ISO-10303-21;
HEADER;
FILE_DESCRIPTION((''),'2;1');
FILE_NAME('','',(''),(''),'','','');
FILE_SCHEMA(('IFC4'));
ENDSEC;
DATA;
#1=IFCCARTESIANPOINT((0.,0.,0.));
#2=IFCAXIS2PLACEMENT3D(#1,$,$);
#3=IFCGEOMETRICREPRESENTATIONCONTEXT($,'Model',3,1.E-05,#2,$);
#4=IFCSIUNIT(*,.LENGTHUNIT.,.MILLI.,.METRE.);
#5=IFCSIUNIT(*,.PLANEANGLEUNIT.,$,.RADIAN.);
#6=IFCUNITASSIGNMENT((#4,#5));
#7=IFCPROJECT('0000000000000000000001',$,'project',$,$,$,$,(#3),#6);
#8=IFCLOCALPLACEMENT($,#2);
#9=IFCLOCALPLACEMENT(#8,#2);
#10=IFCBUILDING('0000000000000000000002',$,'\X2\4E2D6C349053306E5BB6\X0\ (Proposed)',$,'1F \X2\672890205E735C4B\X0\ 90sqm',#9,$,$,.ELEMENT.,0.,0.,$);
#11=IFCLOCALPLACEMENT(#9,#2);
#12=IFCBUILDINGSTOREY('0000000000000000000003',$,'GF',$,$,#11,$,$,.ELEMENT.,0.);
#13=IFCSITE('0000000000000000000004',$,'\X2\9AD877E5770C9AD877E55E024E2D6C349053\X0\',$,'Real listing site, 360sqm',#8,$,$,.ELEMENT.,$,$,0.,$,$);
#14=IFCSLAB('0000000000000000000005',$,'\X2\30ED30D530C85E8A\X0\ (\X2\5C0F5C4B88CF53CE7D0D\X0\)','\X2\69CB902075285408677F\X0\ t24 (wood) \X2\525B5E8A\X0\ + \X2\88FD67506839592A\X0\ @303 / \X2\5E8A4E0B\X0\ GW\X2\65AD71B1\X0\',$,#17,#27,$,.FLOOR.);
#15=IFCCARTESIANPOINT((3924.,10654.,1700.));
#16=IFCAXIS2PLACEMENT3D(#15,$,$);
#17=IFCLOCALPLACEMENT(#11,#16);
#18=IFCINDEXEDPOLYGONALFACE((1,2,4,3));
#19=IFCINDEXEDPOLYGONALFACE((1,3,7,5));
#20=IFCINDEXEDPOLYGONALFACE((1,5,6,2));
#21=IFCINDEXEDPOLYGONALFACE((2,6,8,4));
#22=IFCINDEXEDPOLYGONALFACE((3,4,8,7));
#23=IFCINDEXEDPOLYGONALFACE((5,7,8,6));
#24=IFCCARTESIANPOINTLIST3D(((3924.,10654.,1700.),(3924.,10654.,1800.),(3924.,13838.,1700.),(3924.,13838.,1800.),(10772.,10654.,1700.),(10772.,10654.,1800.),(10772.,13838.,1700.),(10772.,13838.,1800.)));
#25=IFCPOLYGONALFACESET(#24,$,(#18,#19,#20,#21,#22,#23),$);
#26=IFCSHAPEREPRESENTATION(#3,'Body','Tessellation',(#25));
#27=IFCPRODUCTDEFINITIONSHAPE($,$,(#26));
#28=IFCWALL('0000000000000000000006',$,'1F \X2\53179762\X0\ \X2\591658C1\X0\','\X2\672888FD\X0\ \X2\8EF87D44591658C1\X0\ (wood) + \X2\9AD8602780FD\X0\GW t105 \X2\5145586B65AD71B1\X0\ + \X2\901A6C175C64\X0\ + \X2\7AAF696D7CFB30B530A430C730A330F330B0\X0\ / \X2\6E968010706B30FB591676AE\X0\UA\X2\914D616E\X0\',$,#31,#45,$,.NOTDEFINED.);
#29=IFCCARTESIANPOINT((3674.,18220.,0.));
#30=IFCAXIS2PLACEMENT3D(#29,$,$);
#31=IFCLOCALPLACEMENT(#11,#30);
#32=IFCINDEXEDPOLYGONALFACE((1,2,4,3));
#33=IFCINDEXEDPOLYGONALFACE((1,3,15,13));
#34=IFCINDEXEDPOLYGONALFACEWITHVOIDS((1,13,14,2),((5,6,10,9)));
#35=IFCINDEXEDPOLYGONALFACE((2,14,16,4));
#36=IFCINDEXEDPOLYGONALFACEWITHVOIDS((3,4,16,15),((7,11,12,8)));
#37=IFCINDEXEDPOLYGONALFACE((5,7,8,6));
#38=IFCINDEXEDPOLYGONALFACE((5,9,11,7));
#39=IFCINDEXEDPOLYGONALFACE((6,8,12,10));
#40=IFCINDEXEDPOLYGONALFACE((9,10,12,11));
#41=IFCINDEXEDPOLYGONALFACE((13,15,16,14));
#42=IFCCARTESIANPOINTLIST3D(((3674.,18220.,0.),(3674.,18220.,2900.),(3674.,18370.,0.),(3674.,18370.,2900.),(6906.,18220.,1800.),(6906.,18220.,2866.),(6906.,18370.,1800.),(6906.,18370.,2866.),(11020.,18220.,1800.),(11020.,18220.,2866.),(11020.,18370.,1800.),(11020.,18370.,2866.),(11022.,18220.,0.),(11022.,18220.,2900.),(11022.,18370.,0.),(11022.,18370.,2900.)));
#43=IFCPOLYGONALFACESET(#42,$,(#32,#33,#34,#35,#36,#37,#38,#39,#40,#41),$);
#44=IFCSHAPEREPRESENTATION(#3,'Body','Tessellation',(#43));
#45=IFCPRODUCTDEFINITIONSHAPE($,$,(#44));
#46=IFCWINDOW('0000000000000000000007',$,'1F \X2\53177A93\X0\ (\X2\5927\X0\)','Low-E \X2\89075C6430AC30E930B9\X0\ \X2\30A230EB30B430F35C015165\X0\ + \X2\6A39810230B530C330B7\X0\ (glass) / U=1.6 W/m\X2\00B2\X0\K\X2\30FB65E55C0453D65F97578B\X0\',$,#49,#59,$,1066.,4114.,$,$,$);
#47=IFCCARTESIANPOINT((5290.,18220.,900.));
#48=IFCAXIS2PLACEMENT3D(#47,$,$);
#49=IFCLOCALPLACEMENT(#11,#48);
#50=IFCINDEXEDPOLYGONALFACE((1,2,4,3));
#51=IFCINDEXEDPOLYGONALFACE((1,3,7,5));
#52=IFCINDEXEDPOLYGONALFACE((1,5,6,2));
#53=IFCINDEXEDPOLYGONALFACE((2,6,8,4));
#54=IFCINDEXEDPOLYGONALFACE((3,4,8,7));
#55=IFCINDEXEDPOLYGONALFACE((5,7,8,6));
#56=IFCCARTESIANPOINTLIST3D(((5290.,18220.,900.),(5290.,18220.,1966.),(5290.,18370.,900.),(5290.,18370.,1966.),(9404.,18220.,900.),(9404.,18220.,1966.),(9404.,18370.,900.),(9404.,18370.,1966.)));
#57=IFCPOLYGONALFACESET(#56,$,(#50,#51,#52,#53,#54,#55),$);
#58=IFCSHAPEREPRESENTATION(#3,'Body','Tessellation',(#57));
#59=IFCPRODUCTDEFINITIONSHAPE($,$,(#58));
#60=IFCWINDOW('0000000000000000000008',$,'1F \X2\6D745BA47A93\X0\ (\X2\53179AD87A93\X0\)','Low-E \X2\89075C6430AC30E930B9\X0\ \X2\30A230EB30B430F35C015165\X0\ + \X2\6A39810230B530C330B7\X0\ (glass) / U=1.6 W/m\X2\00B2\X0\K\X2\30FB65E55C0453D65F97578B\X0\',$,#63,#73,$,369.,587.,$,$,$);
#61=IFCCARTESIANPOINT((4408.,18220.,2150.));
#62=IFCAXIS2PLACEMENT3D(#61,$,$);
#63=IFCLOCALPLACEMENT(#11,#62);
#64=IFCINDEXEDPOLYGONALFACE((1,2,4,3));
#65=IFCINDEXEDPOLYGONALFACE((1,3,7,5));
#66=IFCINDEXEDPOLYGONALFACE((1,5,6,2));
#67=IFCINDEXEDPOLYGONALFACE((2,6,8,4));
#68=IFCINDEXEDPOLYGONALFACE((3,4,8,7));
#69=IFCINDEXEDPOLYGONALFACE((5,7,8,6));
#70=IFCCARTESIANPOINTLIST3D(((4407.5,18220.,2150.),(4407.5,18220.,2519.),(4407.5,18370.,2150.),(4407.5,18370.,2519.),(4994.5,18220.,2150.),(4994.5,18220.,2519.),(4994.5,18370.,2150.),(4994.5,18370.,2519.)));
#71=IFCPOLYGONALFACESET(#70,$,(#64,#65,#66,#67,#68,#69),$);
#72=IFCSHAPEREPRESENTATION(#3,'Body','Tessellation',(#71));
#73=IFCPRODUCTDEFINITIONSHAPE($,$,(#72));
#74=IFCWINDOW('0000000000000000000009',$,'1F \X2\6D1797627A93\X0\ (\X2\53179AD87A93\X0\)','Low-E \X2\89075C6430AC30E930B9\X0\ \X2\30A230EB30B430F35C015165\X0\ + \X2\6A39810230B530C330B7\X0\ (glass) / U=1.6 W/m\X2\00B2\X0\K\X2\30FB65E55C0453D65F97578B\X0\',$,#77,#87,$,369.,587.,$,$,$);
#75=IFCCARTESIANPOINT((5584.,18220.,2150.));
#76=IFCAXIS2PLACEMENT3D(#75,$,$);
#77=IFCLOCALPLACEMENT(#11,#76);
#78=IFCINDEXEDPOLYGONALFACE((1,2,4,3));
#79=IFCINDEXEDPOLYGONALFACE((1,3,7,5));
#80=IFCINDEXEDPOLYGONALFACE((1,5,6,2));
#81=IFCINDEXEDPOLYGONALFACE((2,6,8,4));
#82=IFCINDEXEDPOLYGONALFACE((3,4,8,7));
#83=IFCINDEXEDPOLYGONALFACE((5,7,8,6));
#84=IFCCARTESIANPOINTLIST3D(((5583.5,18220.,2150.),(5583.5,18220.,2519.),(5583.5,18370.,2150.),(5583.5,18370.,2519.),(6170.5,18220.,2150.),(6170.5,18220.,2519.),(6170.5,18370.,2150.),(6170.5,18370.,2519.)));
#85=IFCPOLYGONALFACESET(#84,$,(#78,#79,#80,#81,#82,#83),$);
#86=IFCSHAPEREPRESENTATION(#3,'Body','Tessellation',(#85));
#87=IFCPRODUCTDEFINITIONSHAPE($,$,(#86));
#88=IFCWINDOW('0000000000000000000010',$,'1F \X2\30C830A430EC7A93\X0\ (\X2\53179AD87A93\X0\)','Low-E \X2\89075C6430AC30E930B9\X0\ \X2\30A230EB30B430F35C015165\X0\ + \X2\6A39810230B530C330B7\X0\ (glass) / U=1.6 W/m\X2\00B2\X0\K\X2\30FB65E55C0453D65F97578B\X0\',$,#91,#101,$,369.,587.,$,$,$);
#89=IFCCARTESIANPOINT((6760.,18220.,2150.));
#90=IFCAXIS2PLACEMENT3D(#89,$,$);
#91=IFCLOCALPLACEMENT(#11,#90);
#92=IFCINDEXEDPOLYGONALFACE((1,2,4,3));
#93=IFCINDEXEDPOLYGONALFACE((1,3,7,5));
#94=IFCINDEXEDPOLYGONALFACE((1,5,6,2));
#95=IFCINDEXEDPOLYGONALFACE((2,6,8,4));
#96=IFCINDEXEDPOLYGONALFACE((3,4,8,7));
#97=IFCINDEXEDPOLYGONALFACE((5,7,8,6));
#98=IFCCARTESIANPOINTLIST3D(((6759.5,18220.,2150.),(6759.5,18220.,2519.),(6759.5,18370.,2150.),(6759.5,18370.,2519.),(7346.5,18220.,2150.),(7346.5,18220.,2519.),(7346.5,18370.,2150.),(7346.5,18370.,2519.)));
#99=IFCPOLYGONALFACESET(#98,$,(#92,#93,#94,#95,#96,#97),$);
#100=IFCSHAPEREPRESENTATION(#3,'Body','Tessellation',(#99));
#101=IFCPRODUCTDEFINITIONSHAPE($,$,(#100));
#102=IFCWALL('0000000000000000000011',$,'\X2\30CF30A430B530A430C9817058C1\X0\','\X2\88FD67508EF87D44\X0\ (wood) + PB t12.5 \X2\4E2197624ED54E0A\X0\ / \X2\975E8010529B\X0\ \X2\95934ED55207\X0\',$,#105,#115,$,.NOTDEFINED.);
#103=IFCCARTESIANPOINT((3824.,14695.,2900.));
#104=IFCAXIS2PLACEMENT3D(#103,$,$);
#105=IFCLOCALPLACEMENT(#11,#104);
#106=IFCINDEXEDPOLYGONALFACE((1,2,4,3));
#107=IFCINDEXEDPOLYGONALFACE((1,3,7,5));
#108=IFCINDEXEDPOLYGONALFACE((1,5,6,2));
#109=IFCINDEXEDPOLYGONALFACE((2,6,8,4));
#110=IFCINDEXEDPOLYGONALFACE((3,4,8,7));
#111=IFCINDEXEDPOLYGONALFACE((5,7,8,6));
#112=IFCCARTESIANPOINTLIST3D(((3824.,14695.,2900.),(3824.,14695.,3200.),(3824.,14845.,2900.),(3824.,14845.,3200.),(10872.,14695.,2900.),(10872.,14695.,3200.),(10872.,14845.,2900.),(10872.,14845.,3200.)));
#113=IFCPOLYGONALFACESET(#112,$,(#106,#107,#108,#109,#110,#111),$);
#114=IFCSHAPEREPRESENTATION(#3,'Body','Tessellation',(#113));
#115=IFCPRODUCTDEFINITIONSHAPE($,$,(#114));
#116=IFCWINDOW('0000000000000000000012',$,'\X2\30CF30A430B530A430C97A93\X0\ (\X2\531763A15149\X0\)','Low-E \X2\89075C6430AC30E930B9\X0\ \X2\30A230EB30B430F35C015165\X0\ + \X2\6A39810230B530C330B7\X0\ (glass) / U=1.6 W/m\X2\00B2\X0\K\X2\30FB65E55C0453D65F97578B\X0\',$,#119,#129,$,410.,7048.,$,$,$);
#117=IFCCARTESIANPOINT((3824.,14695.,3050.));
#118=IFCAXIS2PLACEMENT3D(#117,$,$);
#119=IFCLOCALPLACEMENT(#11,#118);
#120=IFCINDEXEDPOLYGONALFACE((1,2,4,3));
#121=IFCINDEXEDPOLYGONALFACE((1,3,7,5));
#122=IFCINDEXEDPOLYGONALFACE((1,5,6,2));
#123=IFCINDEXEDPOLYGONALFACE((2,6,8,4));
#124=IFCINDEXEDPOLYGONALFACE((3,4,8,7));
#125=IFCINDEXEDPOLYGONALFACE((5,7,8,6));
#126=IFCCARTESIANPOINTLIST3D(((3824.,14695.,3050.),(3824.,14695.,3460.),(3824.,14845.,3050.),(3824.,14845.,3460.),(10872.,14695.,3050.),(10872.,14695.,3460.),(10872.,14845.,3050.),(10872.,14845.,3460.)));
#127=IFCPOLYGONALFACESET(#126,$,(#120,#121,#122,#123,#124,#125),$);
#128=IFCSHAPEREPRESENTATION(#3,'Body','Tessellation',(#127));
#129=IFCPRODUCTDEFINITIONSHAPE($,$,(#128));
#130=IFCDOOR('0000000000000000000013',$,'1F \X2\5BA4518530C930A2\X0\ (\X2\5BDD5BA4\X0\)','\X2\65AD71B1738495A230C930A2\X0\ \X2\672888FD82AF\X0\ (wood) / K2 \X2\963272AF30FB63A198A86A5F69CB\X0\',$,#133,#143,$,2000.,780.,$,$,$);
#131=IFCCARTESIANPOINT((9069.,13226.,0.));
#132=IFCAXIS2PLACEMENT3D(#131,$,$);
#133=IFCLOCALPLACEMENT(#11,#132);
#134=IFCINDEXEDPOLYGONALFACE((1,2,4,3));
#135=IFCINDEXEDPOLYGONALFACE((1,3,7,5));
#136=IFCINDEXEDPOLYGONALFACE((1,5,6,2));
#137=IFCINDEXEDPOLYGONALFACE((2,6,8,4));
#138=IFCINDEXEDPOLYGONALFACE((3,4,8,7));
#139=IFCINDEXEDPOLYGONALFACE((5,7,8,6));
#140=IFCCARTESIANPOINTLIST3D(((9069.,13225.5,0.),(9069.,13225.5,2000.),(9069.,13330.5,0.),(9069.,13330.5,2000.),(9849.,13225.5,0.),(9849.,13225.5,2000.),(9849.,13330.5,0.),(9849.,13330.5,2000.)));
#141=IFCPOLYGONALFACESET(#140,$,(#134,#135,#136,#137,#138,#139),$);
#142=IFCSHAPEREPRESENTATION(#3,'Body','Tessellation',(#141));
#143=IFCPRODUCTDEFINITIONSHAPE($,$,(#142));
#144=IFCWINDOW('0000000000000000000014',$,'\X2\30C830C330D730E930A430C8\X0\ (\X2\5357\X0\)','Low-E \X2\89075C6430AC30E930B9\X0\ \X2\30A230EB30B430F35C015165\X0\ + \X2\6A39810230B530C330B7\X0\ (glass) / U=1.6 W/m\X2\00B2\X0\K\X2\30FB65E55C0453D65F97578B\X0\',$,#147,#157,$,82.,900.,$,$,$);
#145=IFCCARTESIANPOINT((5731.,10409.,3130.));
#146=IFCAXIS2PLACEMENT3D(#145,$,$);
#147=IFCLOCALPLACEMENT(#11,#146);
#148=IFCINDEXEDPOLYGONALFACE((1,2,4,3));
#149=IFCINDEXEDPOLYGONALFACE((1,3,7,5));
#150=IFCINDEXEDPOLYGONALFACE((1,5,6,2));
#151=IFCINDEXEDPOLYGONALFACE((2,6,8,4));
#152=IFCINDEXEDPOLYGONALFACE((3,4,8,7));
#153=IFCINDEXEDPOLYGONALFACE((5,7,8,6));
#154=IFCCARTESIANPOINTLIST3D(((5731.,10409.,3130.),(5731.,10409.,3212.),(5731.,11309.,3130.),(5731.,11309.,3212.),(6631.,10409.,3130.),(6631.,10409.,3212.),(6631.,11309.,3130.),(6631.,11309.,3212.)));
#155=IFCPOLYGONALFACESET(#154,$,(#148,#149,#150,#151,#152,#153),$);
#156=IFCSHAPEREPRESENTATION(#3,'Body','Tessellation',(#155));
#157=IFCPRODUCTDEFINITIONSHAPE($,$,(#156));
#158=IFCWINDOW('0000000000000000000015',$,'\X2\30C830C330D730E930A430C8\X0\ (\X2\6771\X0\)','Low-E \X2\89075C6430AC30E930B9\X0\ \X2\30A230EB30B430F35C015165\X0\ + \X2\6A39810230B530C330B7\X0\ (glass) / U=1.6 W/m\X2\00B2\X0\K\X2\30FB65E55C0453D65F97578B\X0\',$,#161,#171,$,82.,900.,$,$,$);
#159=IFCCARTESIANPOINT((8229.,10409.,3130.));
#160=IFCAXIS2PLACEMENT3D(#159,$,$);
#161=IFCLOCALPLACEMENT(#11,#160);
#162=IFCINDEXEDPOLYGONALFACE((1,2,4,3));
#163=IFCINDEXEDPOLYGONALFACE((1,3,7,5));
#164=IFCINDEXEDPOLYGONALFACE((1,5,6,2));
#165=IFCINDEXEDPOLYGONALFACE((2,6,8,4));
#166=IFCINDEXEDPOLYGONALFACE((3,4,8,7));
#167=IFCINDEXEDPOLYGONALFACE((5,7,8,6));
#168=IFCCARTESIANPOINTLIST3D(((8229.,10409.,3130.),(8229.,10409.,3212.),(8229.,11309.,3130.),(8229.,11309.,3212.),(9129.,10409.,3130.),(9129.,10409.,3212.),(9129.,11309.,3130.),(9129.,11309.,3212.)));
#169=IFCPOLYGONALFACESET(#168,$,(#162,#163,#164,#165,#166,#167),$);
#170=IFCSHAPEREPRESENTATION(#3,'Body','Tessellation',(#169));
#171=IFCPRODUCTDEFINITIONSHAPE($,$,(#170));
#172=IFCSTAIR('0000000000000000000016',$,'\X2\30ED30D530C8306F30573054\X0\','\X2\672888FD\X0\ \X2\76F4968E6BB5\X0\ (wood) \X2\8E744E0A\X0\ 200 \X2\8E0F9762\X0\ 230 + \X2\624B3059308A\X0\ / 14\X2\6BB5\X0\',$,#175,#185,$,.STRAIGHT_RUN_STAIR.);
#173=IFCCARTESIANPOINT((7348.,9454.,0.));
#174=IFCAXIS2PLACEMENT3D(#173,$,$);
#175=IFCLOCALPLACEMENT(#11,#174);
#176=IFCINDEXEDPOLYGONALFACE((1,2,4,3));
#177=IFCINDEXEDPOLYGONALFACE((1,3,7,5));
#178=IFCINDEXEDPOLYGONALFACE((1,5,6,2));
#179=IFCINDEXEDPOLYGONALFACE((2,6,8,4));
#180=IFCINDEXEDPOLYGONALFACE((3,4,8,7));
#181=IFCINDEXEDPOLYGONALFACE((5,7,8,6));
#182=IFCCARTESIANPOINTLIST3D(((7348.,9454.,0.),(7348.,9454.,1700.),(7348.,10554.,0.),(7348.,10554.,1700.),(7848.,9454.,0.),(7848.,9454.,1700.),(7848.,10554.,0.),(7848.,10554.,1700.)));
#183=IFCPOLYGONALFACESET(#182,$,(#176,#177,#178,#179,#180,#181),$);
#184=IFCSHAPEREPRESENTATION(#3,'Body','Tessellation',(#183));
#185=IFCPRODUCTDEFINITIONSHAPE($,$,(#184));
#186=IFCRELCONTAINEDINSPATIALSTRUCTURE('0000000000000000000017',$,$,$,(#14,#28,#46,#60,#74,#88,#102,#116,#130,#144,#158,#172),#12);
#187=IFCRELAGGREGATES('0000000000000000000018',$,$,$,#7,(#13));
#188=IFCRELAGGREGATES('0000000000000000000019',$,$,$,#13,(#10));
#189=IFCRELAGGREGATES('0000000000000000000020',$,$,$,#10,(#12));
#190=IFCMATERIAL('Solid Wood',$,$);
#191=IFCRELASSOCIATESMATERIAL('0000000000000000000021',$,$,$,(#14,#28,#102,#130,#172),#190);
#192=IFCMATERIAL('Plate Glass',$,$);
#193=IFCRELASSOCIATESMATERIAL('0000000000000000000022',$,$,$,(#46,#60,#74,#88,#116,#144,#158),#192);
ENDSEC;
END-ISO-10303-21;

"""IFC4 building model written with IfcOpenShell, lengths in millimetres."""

from ifc_helpers import new_model, si_unit, frame, frame_2d, origin, place, context, project, spatial, rectangle, extrude, material, element, fill, save


model = new_model("IFC4")

# Units and contexts
model_context = context("Model", 3, precision=1e-05, world=origin())
ifc_project = project(units=[si_unit("LENGTHUNIT", "METRE", prefix="MILLI"), si_unit("PLANEANGLEUNIT", "RADIAN")], contexts=[model_context])

# Site, building, storey
site_placement = place(None, origin())
site = spatial("IfcSite", under=ifc_project, at=site_placement, Name="高知県高知市中水道", ObjectType="Real listing site, 360sqm", CompositionType="ELEMENT", RefElevation=0.0)
building_placement = place(site_placement, origin())
building = spatial("IfcBuilding", under=site, at=building_placement, Name="中水道の家 (Proposed)", ObjectType="1F 木造平屋 90sqm", CompositionType="ELEMENT", ElevationOfRefHeight=0.0, ElevationOfTerrain=0.0)
storey_placement = place(building_placement, origin())
storey = spatial("IfcBuildingStorey", under=building, at=storey_placement, Name="GF", CompositionType="ELEMENT", Elevation=0.0)

# Slab
ifc_material_1 = material(Name="Solid Wood")
slab_placement = place(storey_placement, frame((3924.0, 10654.0, 1700.0)))
element("IfcSlab", 1, at=slab_placement, inside=storey, material=ifc_material_1, Name="ロフト床 (小屋裏収納)", Description="構造用合板 t24 (wood) 剛床 + 製材根太 @303 / 床下 GW断熱", PredefinedType="FLOOR", context=model_context, shape_type="SweptSolid", body=[
    extrude(rectangle(XDim=6848.0, YDim=3184.0, at=frame_2d((3424.0, 1592.0))), frame((3924.0, 10654.0, 1700.0)), (0.0, 0.0, 1.0), 100.0),
])

# Wall, openings, windows
wall_1_placement = place(storey_placement, frame((3674.0, 18220.0, 0.0)))
wall_1 = element("IfcWall", 2, at=wall_1_placement, inside=storey, material=ifc_material_1, Name="1F 北面 外壁", Description="木製 軸組外壁 (wood) + 高性能GW t105 充填断熱 + 通気層 + 窯業系サイディング / 準耐火・外皮UA配慮", PredefinedType="NOTDEFINED", context=model_context, shape_type="SweptSolid", body=[
    extrude(rectangle(XDim=7348.0, YDim=150.0, at=frame_2d((3674.0, 75.0))), frame((3674.0, 18220.0, 0.0)), (0.0, 0.0, 1.0), 2900.0),
])
opening_1_placement = place(storey_placement, frame((5290.0, 18220.0, 900.0)))
opening_1 = element("IfcOpeningElement", 3, at=opening_1_placement, cuts=wall_1, PredefinedType="NOTDEFINED", context=model_context, shape_type="SweptSolid", body=[
    extrude(rectangle(XDim=4114.0, YDim=150.0, at=frame_2d((2057.0, 75.0))), frame((5290.0, 18220.0, 900.0)), (0.0, 0.0, 1.0), 1066.0),
])
opening_2_placement = place(storey_placement, frame((4408.0, 18220.0, 2150.0)))
opening_2 = element("IfcOpeningElement", 4, at=opening_2_placement, cuts=wall_1, PredefinedType="NOTDEFINED", context=model_context, shape_type="SweptSolid", body=[
    extrude(rectangle(XDim=587.0, YDim=150.0, at=frame_2d((293.0, 75.0))), frame((4408.0, 18220.0, 2150.0)), (0.0, 0.0, 1.0), 369.0),
])
opening_3_placement = place(storey_placement, frame((5584.0, 18220.0, 2150.0)))
opening_3 = element("IfcOpeningElement", 5, at=opening_3_placement, cuts=wall_1, PredefinedType="NOTDEFINED", context=model_context, shape_type="SweptSolid", body=[
    extrude(rectangle(XDim=587.0, YDim=150.0, at=frame_2d((293.0, 75.0))), frame((5584.0, 18220.0, 2150.0)), (0.0, 0.0, 1.0), 369.0),
])
opening_4_placement = place(storey_placement, frame((6760.0, 18220.0, 2150.0)))
opening_4 = element("IfcOpeningElement", 6, at=opening_4_placement, cuts=wall_1, PredefinedType="NOTDEFINED", context=model_context, shape_type="SweptSolid", body=[
    extrude(rectangle(XDim=587.0, YDim=150.0, at=frame_2d((293.0, 75.0))), frame((6760.0, 18220.0, 2150.0)), (0.0, 0.0, 1.0), 369.0),
])
ifc_material_2 = material(Name="Plate Glass")
window_1_placement = place(storey_placement, frame((5290.0, 18220.0, 900.0)))
window_1 = element("IfcWindow", 7, at=window_1_placement, inside=storey, material=ifc_material_2, Name="1F 北窓 (大)", Description="Low-E 複層ガラス アルゴン封入 + 樹脂サッシ (glass) / U=1.6 W/m²K・日射取得型", OverallHeight=1066.0, OverallWidth=4114.0, context=model_context, shape_type="SweptSolid", body=[
    extrude(rectangle(XDim=4114.0, YDim=150.0, at=frame_2d((2057.0, 75.0))), frame((5290.0, 18220.0, 900.0)), (0.0, 0.0, 1.0), 1066.0),
])
fill(opening_1, window_1)
window_2_placement = place(storey_placement, frame((4408.0, 18220.0, 2150.0)))
window_2 = element("IfcWindow", 8, at=window_2_placement, inside=storey, material=ifc_material_2, Name="1F 浴室窓 (北高窓)", Description="Low-E 複層ガラス アルゴン封入 + 樹脂サッシ (glass) / U=1.6 W/m²K・日射取得型", OverallHeight=369.0, OverallWidth=587.0, context=model_context, shape_type="SweptSolid", body=[
    extrude(rectangle(XDim=587.0, YDim=150.0, at=frame_2d((293.0, 75.0))), frame((4408.0, 18220.0, 2150.0)), (0.0, 0.0, 1.0), 369.0),
])
fill(opening_2, window_2)
window_3_placement = place(storey_placement, frame((5584.0, 18220.0, 2150.0)))
window_3 = element("IfcWindow", 9, at=window_3_placement, inside=storey, material=ifc_material_2, Name="1F 洗面窓 (北高窓)", Description="Low-E 複層ガラス アルゴン封入 + 樹脂サッシ (glass) / U=1.6 W/m²K・日射取得型", OverallHeight=369.0, OverallWidth=587.0, context=model_context, shape_type="SweptSolid", body=[
    extrude(rectangle(XDim=587.0, YDim=150.0, at=frame_2d((293.0, 75.0))), frame((5584.0, 18220.0, 2150.0)), (0.0, 0.0, 1.0), 369.0),
])
fill(opening_3, window_3)
window_4_placement = place(storey_placement, frame((6760.0, 18220.0, 2150.0)))
window_4 = element("IfcWindow", 10, at=window_4_placement, inside=storey, material=ifc_material_2, Name="1F トイレ窓 (北高窓)", Description="Low-E 複層ガラス アルゴン封入 + 樹脂サッシ (glass) / U=1.6 W/m²K・日射取得型", OverallHeight=369.0, OverallWidth=587.0, context=model_context, shape_type="SweptSolid", body=[
    extrude(rectangle(XDim=587.0, YDim=150.0, at=frame_2d((293.0, 75.0))), frame((6760.0, 18220.0, 2150.0)), (0.0, 0.0, 1.0), 369.0),
])
fill(opening_4, window_4)

# Wall, opening, window
wall_2_placement = place(storey_placement, frame((3824.0, 14695.0, 2900.0)))
wall_2 = element("IfcWall", 11, at=wall_2_placement, inside=storey, material=ifc_material_1, Name="ハイサイド腰壁", Description="製材軸組 (wood) + PB t12.5 両面仕上 / 非耐力 間仕切", PredefinedType="NOTDEFINED", context=model_context, shape_type="SweptSolid", body=[
    extrude(rectangle(XDim=7048.0, YDim=150.0, at=frame_2d((3524.0, 75.0))), frame((3824.0, 14695.0, 2900.0)), (0.0, 0.0, 1.0), 700.0),
])
opening_5_placement = place(storey_placement, frame((3824.0, 14695.0, 3050.0)))
opening_5 = element("IfcOpeningElement", 12, at=opening_5_placement, cuts=wall_2, PredefinedType="NOTDEFINED", context=model_context, shape_type="SweptSolid", body=[
    extrude(rectangle(XDim=7048.0, YDim=150.0, at=frame_2d((3524.0, 75.0))), frame((3824.0, 14695.0, 3050.0)), (0.0, 0.0, 1.0), 410.0),
])
window_5_placement = place(storey_placement, frame((3824.0, 14695.0, 3050.0)))
window_5 = element("IfcWindow", 13, at=window_5_placement, inside=storey, material=ifc_material_2, Name="ハイサイド窓 (北採光)", Description="Low-E 複層ガラス アルゴン封入 + 樹脂サッシ (glass) / U=1.6 W/m²K・日射取得型", OverallHeight=410.0, OverallWidth=7048.0, context=model_context, shape_type="SweptSolid", body=[
    extrude(rectangle(XDim=7048.0, YDim=150.0, at=frame_2d((3524.0, 75.0))), frame((3824.0, 14695.0, 3050.0)), (0.0, 0.0, 1.0), 410.0),
])
fill(opening_5, window_5)

# Door
door_1_placement = place(storey_placement, frame((9069.0, 13226.0, 0.0)))
element("IfcDoor", 14, at=door_1_placement, inside=storey, material=ifc_material_1, Name="1F 室内ドア (寝室)", Description="断熱玄関ドア 木製芯 (wood) / K2 防犯・採風機構", OverallHeight=2000.0, OverallWidth=780.0, context=model_context, shape_type="SweptSolid", body=[
    extrude(rectangle(XDim=780.0, YDim=105.0, at=frame_2d((390.0, 52.0))), frame((9069.0, 13226.0, 0.0)), (0.0, 0.0, 1.0), 2000.0),
])

# Windows
window_6_placement = place(storey_placement, frame((5731.0, 10409.0, 3130.0)))
element("IfcWindow", 15, at=window_6_placement, inside=storey, material=ifc_material_2, Name="トップライト (南)", Description="Low-E 複層ガラス アルゴン封入 + 樹脂サッシ (glass) / U=1.6 W/m²K・日射取得型", OverallHeight=82.0, OverallWidth=900.0, context=model_context, shape_type="SweptSolid", body=[
    extrude(rectangle(XDim=900.0, YDim=900.0, at=frame_2d((450.0, 450.0))), frame((5731.0, 10409.0, 3130.0)), (0.0, 0.0, 1.0), 82.0),
])
window_7_placement = place(storey_placement, frame((8229.0, 10409.0, 3130.0)))
element("IfcWindow", 16, at=window_7_placement, inside=storey, material=ifc_material_2, Name="トップライト (東)", Description="Low-E 複層ガラス アルゴン封入 + 樹脂サッシ (glass) / U=1.6 W/m²K・日射取得型", OverallHeight=82.0, OverallWidth=900.0, context=model_context, shape_type="SweptSolid", body=[
    extrude(rectangle(XDim=900.0, YDim=900.0, at=frame_2d((450.0, 450.0))), frame((8229.0, 10409.0, 3130.0)), (0.0, 0.0, 1.0), 82.0),
])

# Stair
stair_placement = place(storey_placement, frame((7348.0, 9454.0, 0.0)))
element("IfcStair", 17, at=stair_placement, inside=storey, material=ifc_material_1, Name="ロフトはしご", Description="木製 直階段 (wood) 蹴上 200 踏面 230 + 手すり / 14段", PredefinedType="STRAIGHT_RUN_STAIR", context=model_context, shape_type="SweptSolid", body=[
    extrude(rectangle(XDim=500.0, YDim=1100.0, at=frame_2d((250.0, 550.0))), frame((7348.0, 9454.0, 0.0)), (0.0, 0.0, 1.0), 1700.0),
])

save(model, "model.ifc")
